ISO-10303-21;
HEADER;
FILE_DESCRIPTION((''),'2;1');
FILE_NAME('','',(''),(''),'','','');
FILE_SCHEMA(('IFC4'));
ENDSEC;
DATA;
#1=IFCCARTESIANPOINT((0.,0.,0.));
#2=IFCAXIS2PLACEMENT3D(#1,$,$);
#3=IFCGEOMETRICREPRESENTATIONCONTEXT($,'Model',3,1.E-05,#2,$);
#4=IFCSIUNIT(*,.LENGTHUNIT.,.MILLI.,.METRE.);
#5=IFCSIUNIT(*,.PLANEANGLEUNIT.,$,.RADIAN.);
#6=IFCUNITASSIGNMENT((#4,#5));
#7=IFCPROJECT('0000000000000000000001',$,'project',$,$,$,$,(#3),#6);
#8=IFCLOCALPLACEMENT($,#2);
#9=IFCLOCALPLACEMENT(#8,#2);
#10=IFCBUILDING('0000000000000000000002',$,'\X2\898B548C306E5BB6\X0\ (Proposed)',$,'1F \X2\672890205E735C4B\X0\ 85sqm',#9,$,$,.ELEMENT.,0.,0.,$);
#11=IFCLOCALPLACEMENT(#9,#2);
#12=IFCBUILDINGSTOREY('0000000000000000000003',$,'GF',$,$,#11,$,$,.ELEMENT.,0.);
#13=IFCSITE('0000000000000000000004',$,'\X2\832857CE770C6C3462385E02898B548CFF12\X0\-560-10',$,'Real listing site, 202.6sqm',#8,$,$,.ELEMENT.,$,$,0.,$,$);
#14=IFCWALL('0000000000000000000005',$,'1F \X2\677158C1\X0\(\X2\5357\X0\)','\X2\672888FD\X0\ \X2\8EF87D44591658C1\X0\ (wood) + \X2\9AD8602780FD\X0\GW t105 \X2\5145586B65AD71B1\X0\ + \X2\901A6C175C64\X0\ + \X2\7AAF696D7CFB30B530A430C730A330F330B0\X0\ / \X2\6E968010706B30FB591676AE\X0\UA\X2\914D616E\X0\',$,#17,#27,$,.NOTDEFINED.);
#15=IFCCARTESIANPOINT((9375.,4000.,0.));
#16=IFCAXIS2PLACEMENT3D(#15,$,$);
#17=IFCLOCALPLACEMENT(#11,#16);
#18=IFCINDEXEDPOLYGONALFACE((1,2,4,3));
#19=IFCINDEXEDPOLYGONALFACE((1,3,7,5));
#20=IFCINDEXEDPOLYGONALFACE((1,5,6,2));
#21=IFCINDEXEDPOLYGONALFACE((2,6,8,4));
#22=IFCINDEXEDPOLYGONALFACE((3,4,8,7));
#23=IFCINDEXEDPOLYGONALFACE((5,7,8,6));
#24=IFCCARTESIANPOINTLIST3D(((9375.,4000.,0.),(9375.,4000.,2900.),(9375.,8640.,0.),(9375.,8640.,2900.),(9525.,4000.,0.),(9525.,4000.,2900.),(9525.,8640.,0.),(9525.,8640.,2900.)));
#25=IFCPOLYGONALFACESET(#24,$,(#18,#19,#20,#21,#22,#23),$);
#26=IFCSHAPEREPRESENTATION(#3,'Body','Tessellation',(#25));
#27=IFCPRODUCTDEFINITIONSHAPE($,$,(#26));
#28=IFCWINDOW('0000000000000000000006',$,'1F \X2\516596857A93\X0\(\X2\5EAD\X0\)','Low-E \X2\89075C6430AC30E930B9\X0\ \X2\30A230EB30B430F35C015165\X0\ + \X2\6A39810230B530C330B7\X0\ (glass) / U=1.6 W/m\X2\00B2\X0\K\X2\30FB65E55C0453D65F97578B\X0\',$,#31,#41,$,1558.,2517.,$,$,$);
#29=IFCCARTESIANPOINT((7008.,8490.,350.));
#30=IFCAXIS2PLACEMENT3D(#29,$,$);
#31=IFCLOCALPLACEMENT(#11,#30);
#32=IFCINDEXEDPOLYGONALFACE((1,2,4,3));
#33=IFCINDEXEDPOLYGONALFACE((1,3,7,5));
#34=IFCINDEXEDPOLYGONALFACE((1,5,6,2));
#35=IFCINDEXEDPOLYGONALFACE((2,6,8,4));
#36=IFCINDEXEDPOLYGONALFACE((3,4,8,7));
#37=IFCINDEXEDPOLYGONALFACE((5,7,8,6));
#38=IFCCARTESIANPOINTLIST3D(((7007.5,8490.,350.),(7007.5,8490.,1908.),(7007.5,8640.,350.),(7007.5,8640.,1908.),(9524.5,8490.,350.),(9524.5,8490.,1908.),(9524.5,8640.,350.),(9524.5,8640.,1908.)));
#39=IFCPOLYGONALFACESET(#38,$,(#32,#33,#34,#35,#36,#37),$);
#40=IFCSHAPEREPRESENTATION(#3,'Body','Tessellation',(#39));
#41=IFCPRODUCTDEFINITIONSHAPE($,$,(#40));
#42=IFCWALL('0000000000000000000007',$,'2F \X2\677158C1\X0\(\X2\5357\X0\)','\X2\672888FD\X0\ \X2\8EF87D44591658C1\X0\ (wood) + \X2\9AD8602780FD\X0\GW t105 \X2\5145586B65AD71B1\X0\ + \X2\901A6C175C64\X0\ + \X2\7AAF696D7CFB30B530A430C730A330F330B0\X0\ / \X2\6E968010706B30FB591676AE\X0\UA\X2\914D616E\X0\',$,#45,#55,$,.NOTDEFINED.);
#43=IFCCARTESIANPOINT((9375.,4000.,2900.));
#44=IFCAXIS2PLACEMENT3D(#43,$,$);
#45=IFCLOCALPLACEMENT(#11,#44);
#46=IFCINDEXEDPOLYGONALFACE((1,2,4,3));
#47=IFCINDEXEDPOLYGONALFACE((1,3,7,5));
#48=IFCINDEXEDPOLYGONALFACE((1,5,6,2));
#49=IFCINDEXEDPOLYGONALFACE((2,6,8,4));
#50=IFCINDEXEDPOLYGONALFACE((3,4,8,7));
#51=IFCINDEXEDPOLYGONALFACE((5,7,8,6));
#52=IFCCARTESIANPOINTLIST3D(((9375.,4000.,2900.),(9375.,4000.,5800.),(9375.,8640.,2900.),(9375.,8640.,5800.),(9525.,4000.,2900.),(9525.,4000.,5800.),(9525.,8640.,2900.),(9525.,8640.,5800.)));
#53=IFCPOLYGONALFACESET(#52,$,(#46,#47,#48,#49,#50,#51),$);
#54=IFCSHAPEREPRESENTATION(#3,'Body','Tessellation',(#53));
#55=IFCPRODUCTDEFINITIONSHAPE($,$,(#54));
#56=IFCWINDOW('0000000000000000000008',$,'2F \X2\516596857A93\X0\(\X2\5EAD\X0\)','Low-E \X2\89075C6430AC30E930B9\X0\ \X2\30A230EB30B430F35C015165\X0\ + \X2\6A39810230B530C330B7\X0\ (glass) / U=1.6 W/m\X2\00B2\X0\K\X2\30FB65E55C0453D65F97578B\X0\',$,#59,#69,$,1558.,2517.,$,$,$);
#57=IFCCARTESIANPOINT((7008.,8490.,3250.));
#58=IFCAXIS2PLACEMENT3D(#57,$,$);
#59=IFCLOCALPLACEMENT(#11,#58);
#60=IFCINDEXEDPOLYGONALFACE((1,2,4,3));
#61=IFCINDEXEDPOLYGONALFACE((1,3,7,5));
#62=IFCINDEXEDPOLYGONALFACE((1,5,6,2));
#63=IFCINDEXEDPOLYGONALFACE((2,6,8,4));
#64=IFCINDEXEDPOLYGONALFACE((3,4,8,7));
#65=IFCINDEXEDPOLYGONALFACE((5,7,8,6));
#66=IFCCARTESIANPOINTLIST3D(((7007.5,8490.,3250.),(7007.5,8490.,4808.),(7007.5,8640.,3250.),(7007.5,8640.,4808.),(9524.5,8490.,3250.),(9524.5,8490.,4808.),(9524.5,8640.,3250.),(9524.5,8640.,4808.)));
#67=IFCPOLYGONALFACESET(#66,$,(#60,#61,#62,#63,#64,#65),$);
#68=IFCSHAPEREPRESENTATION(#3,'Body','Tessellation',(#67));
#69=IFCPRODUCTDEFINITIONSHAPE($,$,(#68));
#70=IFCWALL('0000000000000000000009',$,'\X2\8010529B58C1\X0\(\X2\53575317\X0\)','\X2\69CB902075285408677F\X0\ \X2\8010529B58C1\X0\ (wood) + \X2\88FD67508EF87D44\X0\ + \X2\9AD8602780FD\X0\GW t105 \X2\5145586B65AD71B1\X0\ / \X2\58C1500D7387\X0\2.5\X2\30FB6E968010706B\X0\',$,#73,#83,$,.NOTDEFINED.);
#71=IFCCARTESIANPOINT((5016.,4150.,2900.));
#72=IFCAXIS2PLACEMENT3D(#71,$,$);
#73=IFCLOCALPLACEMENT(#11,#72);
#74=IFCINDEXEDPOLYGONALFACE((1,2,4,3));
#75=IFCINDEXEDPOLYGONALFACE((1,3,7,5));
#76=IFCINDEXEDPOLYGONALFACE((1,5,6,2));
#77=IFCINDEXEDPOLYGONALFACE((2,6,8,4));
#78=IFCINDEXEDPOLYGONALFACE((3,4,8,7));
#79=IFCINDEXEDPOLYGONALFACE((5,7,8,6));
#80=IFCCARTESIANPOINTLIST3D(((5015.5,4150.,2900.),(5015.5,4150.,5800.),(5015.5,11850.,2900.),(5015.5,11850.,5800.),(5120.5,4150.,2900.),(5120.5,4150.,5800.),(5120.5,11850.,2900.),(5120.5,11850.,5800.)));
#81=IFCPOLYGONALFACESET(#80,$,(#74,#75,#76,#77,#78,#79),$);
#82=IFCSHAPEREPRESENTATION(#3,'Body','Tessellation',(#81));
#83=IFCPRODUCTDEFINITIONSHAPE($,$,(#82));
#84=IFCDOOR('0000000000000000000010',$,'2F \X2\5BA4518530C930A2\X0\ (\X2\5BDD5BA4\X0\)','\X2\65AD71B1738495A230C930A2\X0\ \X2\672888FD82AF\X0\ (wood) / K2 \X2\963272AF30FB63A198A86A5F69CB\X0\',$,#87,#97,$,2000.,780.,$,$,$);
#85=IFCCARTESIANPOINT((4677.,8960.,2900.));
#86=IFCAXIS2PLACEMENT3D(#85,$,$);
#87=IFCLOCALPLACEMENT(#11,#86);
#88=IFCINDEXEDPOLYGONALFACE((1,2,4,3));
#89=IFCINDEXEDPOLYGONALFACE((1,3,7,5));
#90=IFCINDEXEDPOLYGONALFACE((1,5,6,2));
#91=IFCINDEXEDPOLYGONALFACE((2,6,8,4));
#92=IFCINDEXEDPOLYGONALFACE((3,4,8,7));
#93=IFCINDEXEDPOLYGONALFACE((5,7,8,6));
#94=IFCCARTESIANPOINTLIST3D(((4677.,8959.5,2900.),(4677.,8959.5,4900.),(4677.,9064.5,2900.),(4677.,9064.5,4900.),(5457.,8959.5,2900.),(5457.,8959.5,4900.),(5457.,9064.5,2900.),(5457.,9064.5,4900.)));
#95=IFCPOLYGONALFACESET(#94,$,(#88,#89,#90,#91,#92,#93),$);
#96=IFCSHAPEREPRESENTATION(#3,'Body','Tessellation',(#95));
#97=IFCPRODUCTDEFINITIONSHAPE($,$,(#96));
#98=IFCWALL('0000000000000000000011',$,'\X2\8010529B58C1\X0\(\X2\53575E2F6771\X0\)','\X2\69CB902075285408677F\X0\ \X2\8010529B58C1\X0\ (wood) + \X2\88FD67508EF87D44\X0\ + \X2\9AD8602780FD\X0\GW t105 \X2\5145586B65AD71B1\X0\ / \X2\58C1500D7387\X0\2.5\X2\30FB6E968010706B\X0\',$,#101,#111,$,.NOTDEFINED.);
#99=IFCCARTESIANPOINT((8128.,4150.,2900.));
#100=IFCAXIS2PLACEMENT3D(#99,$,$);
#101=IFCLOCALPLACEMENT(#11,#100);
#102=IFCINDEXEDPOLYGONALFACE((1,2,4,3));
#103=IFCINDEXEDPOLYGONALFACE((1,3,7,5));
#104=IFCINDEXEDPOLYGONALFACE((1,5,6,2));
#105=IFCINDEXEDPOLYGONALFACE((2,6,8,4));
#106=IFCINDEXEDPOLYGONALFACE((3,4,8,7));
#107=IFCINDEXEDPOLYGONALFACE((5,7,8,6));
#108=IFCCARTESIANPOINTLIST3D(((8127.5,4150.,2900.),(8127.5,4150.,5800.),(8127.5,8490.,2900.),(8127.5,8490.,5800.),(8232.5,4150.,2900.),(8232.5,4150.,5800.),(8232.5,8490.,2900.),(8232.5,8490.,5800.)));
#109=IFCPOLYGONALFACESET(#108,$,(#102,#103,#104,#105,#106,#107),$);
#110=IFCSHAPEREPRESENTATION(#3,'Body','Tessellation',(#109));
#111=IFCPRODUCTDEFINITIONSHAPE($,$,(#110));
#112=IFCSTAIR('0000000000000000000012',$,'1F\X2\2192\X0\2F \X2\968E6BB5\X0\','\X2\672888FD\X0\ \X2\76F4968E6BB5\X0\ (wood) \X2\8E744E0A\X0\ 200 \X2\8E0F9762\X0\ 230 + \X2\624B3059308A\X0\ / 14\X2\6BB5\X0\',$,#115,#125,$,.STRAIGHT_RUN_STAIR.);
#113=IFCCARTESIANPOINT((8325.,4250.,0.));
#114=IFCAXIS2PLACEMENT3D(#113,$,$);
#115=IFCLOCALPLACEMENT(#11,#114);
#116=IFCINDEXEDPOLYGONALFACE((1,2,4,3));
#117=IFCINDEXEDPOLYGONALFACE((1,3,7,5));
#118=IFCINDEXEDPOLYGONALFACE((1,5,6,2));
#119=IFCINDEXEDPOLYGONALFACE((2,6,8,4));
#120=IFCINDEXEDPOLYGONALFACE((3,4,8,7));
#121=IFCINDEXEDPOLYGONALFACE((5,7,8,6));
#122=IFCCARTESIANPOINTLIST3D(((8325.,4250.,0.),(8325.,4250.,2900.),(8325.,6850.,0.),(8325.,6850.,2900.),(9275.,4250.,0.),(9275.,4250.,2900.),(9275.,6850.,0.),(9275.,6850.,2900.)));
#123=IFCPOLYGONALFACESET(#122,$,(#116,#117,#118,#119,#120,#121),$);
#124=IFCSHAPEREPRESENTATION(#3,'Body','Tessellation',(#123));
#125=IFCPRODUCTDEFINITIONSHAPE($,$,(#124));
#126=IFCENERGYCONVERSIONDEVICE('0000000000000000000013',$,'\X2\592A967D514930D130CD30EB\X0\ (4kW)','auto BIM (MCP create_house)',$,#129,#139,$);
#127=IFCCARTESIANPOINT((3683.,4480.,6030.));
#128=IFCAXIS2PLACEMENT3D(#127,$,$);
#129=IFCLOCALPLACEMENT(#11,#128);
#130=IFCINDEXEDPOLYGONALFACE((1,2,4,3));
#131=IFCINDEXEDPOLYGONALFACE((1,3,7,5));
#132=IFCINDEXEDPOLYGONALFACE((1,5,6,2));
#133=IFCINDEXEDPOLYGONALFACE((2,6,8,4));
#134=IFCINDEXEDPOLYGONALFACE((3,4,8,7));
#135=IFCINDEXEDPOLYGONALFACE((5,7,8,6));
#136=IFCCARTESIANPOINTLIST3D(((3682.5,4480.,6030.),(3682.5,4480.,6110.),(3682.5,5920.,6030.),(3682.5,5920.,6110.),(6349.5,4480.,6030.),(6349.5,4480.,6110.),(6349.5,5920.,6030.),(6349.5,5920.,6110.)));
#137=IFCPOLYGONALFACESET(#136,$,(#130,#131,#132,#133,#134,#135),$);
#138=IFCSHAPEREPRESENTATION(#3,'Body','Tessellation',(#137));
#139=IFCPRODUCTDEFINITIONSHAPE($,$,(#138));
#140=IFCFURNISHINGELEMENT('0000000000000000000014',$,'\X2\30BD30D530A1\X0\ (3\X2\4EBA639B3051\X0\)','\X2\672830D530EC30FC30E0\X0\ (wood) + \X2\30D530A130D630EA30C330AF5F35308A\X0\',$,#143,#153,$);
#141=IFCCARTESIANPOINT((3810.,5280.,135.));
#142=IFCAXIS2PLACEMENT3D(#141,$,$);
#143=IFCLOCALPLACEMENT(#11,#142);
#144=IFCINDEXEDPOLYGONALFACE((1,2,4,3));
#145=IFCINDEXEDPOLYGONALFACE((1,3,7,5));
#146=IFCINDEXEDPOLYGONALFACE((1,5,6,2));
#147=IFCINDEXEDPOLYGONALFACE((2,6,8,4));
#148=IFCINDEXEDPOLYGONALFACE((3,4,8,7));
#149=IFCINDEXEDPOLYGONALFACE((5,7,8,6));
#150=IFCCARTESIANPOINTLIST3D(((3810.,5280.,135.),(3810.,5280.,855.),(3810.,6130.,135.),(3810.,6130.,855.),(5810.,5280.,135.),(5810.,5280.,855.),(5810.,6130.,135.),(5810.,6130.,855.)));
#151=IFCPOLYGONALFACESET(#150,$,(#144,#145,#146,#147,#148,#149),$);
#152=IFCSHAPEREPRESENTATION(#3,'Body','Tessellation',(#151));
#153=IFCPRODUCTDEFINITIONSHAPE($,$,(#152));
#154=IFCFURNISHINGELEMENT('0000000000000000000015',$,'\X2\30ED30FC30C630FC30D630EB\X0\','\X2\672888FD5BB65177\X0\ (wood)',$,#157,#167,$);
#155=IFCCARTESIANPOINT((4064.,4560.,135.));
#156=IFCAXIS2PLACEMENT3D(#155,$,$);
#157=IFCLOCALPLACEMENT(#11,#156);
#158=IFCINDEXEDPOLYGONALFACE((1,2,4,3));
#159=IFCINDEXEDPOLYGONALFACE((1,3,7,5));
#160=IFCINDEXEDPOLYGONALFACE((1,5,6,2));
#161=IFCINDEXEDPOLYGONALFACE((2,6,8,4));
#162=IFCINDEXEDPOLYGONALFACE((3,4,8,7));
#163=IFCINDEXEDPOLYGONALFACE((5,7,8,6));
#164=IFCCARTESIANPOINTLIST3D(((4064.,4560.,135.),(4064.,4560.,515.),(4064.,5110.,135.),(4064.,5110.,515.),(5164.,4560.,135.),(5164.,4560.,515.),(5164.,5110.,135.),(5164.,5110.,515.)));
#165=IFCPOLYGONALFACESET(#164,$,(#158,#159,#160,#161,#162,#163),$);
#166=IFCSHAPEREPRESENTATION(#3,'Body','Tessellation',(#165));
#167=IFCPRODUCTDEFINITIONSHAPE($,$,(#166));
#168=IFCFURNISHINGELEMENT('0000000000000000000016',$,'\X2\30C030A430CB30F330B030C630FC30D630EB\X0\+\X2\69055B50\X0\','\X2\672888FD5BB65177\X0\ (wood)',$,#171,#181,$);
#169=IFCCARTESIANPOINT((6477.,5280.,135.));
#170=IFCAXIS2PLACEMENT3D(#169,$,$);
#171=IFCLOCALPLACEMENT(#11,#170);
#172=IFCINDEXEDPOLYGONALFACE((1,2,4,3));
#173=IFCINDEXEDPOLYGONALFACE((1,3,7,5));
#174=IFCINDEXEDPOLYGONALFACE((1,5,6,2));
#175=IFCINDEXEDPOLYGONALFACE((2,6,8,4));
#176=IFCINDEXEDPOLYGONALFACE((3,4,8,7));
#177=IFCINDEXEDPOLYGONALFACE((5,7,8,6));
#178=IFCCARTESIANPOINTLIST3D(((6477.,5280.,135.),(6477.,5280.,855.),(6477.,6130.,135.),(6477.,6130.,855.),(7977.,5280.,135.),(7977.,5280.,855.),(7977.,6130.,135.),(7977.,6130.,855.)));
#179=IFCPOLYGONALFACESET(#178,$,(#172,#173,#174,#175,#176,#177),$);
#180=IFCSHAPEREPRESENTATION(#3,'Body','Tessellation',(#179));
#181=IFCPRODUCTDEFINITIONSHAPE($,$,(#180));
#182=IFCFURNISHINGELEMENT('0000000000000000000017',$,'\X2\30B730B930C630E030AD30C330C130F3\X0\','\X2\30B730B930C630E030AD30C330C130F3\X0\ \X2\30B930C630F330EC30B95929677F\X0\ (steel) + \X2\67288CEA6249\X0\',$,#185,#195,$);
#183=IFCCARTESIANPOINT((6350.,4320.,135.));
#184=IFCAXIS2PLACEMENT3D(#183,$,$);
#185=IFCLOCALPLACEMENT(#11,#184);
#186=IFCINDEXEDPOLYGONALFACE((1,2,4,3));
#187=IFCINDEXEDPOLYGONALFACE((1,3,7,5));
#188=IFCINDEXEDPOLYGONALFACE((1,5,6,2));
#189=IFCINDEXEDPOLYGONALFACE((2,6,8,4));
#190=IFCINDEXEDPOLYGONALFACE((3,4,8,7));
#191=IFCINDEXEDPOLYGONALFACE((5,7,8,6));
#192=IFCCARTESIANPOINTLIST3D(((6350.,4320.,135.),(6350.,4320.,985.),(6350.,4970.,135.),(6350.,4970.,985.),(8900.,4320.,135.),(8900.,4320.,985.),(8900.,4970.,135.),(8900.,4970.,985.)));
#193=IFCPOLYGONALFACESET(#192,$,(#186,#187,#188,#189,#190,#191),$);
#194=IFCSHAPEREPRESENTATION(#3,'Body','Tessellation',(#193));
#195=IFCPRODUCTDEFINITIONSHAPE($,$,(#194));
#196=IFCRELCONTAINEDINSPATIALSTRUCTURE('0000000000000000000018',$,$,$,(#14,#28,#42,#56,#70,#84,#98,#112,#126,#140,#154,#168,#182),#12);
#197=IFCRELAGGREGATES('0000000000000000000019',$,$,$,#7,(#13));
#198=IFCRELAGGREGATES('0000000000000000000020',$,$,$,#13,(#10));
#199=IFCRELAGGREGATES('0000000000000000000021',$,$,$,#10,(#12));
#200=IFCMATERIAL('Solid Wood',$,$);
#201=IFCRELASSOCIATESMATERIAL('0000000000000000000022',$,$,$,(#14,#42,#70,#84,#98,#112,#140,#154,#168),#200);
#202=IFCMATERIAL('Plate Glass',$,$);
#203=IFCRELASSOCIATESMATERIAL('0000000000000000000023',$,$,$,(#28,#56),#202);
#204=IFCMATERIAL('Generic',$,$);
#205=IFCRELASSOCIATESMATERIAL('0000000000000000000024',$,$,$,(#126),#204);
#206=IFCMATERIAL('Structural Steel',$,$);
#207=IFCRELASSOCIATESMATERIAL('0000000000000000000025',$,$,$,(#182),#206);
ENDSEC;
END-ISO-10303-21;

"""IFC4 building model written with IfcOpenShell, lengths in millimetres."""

from ifc_helpers import new_model, si_unit, frame, frame_2d, origin, place, context, project, spatial, rectangle, extrude, material, element, fill, save


model = new_model("IFC4")

# Units and contexts
model_context = context("Model", 3, precision=1e-05, world=origin())
ifc_project = project(units=[si_unit("LENGTHUNIT", "METRE", prefix="MILLI"), si_unit("PLANEANGLEUNIT", "RADIAN")], contexts=[model_context])

# Site, building, storey
site_placement = place(None, origin())
site = spatial("IfcSite", under=ifc_project, at=site_placement, Name="茨城県水戸市見和２-560-10", ObjectType="Real listing site, 202.6sqm", CompositionType="ELEMENT", RefElevation=0.0)
building_placement = place(site_placement, origin())
building = spatial("IfcBuilding", under=site, at=building_placement, Name="見和の家 (Proposed)", ObjectType="1F 木造平屋 85sqm", CompositionType="ELEMENT", ElevationOfRefHeight=0.0, ElevationOfTerrain=0.0)
storey_placement = place(building_placement, origin())
storey = spatial("IfcBuildingStorey", under=building, at=storey_placement, Name="GF", CompositionType="ELEMENT", Elevation=0.0)

# Wall, opening, window
ifc_material_1 = material(Name="Solid Wood")
wall_1_placement = place(storey_placement, frame((9375.0, 4000.0, 0.0)))
wall_1 = element("IfcWall", 1, at=wall_1_placement, inside=storey, material=ifc_material_1, Name="1F 東壁(南)", Description="木製 軸組外壁 (wood) + 高性能GW t105 充填断熱 + 通気層 + 窯業系サイディング / 準耐火・外皮UA配慮", PredefinedType="NOTDEFINED", context=model_context, shape_type="SweptSolid", body=[
    extrude(rectangle(XDim=150.0, YDim=4640.0, at=frame_2d((75.0, 2320.0))), frame((9375.0, 4000.0, 0.0)), (0.0, 0.0, 1.0), 2900.0),
])
opening_1_placement = place(storey_placement, frame((7008.0, 8490.0, 350.0)))
opening_1 = element("IfcOpeningElement", 2, at=opening_1_placement, cuts=wall_1, PredefinedType="NOTDEFINED", context=model_context, shape_type="SweptSolid", body=[
    extrude(rectangle(XDim=2517.0, YDim=150.0, at=frame_2d((1258.0, 75.0))), frame((7008.0, 8490.0, 350.0)), (0.0, 0.0, 1.0), 1558.0),
])
ifc_material_2 = material(Name="Plate Glass")
window_1_placement = place(storey_placement, frame((7008.0, 8490.0, 350.0)))
window_1 = element("IfcWindow", 3, at=window_1_placement, inside=storey, material=ifc_material_2, Name="1F 入隅窓(庭)", Description="Low-E 複層ガラス アルゴン封入 + 樹脂サッシ (glass) / U=1.6 W/m²K・日射取得型", OverallHeight=1558.0, OverallWidth=2517.0, context=model_context, shape_type="SweptSolid", body=[
    extrude(rectangle(XDim=2517.0, YDim=150.0, at=frame_2d((1258.0, 75.0))), frame((7008.0, 8490.0, 350.0)), (0.0, 0.0, 1.0), 1558.0),
])
fill(opening_1, window_1)

# Wall, opening, window
wall_2_placement = place(storey_placement, frame((9375.0, 4000.0, 2900.0)))
wall_2 = element("IfcWall", 4, at=wall_2_placement, inside=storey, material=ifc_material_1, Name="2F 東壁(南)", Description="木製 軸組外壁 (wood) + 高性能GW t105 充填断熱 + 通気層 + 窯業系サイディング / 準耐火・外皮UA配慮", PredefinedType="NOTDEFINED", context=model_context, shape_type="SweptSolid", body=[
    extrude(rectangle(XDim=150.0, YDim=4640.0, at=frame_2d((75.0, 2320.0))), frame((9375.0, 4000.0, 2900.0)), (0.0, 0.0, 1.0), 2900.0),
])
opening_2_placement = place(storey_placement, frame((7008.0, 8490.0, 3250.0)))
opening_2 = element("IfcOpeningElement", 5, at=opening_2_placement, cuts=wall_2, PredefinedType="NOTDEFINED", context=model_context, shape_type="SweptSolid", body=[
    extrude(rectangle(XDim=2517.0, YDim=150.0, at=frame_2d((1258.0, 75.0))), frame((7008.0, 8490.0, 3250.0)), (0.0, 0.0, 1.0), 1558.0),
])
window_2_placement = place(storey_placement, frame((7008.0, 8490.0, 3250.0)))
window_2 = element("IfcWindow", 6, at=window_2_placement, inside=storey, material=ifc_material_2, Name="2F 入隅窓(庭)", Description="Low-E 複層ガラス アルゴン封入 + 樹脂サッシ (glass) / U=1.6 W/m²K・日射取得型", OverallHeight=1558.0, OverallWidth=2517.0, context=model_context, shape_type="SweptSolid", body=[
    extrude(rectangle(XDim=2517.0, YDim=150.0, at=frame_2d((1258.0, 75.0))), frame((7008.0, 8490.0, 3250.0)), (0.0, 0.0, 1.0), 1558.0),
])
fill(opening_2, window_2)

# Wall, opening, door
wall_3_placement = place(storey_placement, frame((5016.0, 4150.0, 2900.0)))
wall_3 = element("IfcWall", 7, at=wall_3_placement, inside=storey, material=ifc_material_1, Name="耐力壁(南北)", Description="構造用合板 耐力壁 (wood) + 製材軸組 + 高性能GW t105 充填断熱 / 壁倍率2.5・準耐火", PredefinedType="NOTDEFINED", context=model_context, shape_type="SweptSolid", body=[
    extrude(rectangle(XDim=105.0, YDim=7700.0, at=frame_2d((52.0, 3850.0))), frame((5016.0, 4150.0, 2900.0)), (0.0, 0.0, 1.0), 2900.0),
])
opening_3_placement = place(storey_placement, frame((4677.0, 8960.0, 2900.0)))
opening_3 = element("IfcOpeningElement", 8, at=opening_3_placement, cuts=wall_3, PredefinedType="NOTDEFINED", context=model_context, shape_type="SweptSolid", body=[
    extrude(rectangle(XDim=780.0, YDim=105.0, at=frame_2d((390.0, 52.0))), frame((4677.0, 8960.0, 2900.0)), (0.0, 0.0, 1.0), 2000.0),
])
door_1_placement = place(storey_placement, frame((4677.0, 8960.0, 2900.0)))
door_1 = element("IfcDoor", 9, at=door_1_placement, inside=storey, material=ifc_material_1, Name="2F 室内ドア (寝室)", Description="断熱玄関ドア 木製芯 (wood) / K2 防犯・採風機構", OverallHeight=2000.0, OverallWidth=780.0, context=model_context, shape_type="SweptSolid", body=[
    extrude(rectangle(XDim=780.0, YDim=105.0, at=frame_2d((390.0, 52.0))), frame((4677.0, 8960.0, 2900.0)), (0.0, 0.0, 1.0), 2000.0),
])
fill(opening_3, door_1)

# Wall
wall_4_placement = place(storey_placement, frame((8128.0, 4150.0, 2900.0)))
element("IfcWall", 10, at=wall_4_placement, inside=storey, material=ifc_material_1, Name="耐力壁(南帯東)", Description="構造用合板 耐力壁 (wood) + 製材軸組 + 高性能GW t105 充填断熱 / 壁倍率2.5・準耐火", PredefinedType="NOTDEFINED", context=model_context, shape_type="SweptSolid", body=[
    extrude(rectangle(XDim=105.0, YDim=4340.0, at=frame_2d((52.0, 2170.0))), frame((8128.0, 4150.0, 2900.0)), (0.0, 0.0, 1.0), 2900.0),
])

# Stair
stair_placement = place(storey_placement, frame((8325.0, 4250.0, 0.0)))
element("IfcStair", 11, at=stair_placement, inside=storey, material=ifc_material_1, Name="1F→2F 階段", Description="木製 直階段 (wood) 蹴上 200 踏面 230 + 手すり / 14段", PredefinedType="STRAIGHT_RUN_STAIR", context=model_context, shape_type="SweptSolid", body=[
    extrude(rectangle(XDim=950.0, YDim=2600.0, at=frame_2d((475.0, 1300.0))), frame((8325.0, 4250.0, 0.0)), (0.0, 0.0, 1.0), 2900.0),
])

# Energy conversion device
ifc_material_3 = material(Name="Generic")
energy_conversion_device_placement = place(storey_placement, frame((3683.0, 4480.0, 6030.0)))
element("IfcEnergyConversionDevice", 12, at=energy_conversion_device_placement, inside=storey, material=ifc_material_3, Name="太陽光パネル (4kW)", Description="auto BIM (MCP create_house)", context=model_context, shape_type="SweptSolid", body=[
    extrude(rectangle(XDim=2667.0, YDim=1440.0, at=frame_2d((1333.0, 720.0))), frame((3683.0, 4480.0, 6030.0)), (0.0, 0.0, 1.0), 80.0),
])

# Furnishing elements
furnishing_1_placement = place(storey_placement, frame((3810.0, 5280.0, 135.0)))
element("IfcFurnishingElement", 13, at=furnishing_1_placement, inside=storey, material=ifc_material_1, Name="ソファ (3人掛け)", Description="木フレーム (wood) + ファブリック張り", context=model_context, shape_type="SweptSolid", body=[
    extrude(rectangle(XDim=2000.0, YDim=850.0, at=frame_2d((1000.0, 425.0))), frame((3810.0, 5280.0, 135.0)), (0.0, 0.0, 1.0), 720.0),
])
furnishing_2_placement = place(storey_placement, frame((4064.0, 4560.0, 135.0)))
element("IfcFurnishingElement", 14, at=furnishing_2_placement, inside=storey, material=ifc_material_1, Name="ローテーブル", Description="木製家具 (wood)", context=model_context, shape_type="SweptSolid", body=[
    extrude(rectangle(XDim=1100.0, YDim=550.0, at=frame_2d((550.0, 275.0))), frame((4064.0, 4560.0, 135.0)), (0.0, 0.0, 1.0), 380.0),
])
furnishing_3_placement = place(storey_placement, frame((6477.0, 5280.0, 135.0)))
element("IfcFurnishingElement", 15, at=furnishing_3_placement, inside=storey, material=ifc_material_1, Name="ダイニングテーブル+椅子", Description="木製家具 (wood)", context=model_context, shape_type="SweptSolid", body=[
    extrude(rectangle(XDim=1500.0, YDim=850.0, at=frame_2d((750.0, 425.0))), frame((6477.0, 5280.0, 135.0)), (0.0, 0.0, 1.0), 720.0),
])
ifc_material_4 = material(Name="Structural Steel")
furnishing_4_placement = place(storey_placement, frame((6350.0, 4320.0, 135.0)))
element("IfcFurnishingElement", 16, at=furnishing_4_placement, inside=storey, material=ifc_material_4, Name="システムキッチン", Description="システムキッチン ステンレス天板 (steel) + 木質扉", context=model_context, shape_type="SweptSolid", body=[
    extrude(rectangle(XDim=2550.0, YDim=650.0, at=frame_2d((1275.0, 325.0))), frame((6350.0, 4320.0, 135.0)), (0.0, 0.0, 1.0), 850.0),
])

save(model, "model.ifc")
